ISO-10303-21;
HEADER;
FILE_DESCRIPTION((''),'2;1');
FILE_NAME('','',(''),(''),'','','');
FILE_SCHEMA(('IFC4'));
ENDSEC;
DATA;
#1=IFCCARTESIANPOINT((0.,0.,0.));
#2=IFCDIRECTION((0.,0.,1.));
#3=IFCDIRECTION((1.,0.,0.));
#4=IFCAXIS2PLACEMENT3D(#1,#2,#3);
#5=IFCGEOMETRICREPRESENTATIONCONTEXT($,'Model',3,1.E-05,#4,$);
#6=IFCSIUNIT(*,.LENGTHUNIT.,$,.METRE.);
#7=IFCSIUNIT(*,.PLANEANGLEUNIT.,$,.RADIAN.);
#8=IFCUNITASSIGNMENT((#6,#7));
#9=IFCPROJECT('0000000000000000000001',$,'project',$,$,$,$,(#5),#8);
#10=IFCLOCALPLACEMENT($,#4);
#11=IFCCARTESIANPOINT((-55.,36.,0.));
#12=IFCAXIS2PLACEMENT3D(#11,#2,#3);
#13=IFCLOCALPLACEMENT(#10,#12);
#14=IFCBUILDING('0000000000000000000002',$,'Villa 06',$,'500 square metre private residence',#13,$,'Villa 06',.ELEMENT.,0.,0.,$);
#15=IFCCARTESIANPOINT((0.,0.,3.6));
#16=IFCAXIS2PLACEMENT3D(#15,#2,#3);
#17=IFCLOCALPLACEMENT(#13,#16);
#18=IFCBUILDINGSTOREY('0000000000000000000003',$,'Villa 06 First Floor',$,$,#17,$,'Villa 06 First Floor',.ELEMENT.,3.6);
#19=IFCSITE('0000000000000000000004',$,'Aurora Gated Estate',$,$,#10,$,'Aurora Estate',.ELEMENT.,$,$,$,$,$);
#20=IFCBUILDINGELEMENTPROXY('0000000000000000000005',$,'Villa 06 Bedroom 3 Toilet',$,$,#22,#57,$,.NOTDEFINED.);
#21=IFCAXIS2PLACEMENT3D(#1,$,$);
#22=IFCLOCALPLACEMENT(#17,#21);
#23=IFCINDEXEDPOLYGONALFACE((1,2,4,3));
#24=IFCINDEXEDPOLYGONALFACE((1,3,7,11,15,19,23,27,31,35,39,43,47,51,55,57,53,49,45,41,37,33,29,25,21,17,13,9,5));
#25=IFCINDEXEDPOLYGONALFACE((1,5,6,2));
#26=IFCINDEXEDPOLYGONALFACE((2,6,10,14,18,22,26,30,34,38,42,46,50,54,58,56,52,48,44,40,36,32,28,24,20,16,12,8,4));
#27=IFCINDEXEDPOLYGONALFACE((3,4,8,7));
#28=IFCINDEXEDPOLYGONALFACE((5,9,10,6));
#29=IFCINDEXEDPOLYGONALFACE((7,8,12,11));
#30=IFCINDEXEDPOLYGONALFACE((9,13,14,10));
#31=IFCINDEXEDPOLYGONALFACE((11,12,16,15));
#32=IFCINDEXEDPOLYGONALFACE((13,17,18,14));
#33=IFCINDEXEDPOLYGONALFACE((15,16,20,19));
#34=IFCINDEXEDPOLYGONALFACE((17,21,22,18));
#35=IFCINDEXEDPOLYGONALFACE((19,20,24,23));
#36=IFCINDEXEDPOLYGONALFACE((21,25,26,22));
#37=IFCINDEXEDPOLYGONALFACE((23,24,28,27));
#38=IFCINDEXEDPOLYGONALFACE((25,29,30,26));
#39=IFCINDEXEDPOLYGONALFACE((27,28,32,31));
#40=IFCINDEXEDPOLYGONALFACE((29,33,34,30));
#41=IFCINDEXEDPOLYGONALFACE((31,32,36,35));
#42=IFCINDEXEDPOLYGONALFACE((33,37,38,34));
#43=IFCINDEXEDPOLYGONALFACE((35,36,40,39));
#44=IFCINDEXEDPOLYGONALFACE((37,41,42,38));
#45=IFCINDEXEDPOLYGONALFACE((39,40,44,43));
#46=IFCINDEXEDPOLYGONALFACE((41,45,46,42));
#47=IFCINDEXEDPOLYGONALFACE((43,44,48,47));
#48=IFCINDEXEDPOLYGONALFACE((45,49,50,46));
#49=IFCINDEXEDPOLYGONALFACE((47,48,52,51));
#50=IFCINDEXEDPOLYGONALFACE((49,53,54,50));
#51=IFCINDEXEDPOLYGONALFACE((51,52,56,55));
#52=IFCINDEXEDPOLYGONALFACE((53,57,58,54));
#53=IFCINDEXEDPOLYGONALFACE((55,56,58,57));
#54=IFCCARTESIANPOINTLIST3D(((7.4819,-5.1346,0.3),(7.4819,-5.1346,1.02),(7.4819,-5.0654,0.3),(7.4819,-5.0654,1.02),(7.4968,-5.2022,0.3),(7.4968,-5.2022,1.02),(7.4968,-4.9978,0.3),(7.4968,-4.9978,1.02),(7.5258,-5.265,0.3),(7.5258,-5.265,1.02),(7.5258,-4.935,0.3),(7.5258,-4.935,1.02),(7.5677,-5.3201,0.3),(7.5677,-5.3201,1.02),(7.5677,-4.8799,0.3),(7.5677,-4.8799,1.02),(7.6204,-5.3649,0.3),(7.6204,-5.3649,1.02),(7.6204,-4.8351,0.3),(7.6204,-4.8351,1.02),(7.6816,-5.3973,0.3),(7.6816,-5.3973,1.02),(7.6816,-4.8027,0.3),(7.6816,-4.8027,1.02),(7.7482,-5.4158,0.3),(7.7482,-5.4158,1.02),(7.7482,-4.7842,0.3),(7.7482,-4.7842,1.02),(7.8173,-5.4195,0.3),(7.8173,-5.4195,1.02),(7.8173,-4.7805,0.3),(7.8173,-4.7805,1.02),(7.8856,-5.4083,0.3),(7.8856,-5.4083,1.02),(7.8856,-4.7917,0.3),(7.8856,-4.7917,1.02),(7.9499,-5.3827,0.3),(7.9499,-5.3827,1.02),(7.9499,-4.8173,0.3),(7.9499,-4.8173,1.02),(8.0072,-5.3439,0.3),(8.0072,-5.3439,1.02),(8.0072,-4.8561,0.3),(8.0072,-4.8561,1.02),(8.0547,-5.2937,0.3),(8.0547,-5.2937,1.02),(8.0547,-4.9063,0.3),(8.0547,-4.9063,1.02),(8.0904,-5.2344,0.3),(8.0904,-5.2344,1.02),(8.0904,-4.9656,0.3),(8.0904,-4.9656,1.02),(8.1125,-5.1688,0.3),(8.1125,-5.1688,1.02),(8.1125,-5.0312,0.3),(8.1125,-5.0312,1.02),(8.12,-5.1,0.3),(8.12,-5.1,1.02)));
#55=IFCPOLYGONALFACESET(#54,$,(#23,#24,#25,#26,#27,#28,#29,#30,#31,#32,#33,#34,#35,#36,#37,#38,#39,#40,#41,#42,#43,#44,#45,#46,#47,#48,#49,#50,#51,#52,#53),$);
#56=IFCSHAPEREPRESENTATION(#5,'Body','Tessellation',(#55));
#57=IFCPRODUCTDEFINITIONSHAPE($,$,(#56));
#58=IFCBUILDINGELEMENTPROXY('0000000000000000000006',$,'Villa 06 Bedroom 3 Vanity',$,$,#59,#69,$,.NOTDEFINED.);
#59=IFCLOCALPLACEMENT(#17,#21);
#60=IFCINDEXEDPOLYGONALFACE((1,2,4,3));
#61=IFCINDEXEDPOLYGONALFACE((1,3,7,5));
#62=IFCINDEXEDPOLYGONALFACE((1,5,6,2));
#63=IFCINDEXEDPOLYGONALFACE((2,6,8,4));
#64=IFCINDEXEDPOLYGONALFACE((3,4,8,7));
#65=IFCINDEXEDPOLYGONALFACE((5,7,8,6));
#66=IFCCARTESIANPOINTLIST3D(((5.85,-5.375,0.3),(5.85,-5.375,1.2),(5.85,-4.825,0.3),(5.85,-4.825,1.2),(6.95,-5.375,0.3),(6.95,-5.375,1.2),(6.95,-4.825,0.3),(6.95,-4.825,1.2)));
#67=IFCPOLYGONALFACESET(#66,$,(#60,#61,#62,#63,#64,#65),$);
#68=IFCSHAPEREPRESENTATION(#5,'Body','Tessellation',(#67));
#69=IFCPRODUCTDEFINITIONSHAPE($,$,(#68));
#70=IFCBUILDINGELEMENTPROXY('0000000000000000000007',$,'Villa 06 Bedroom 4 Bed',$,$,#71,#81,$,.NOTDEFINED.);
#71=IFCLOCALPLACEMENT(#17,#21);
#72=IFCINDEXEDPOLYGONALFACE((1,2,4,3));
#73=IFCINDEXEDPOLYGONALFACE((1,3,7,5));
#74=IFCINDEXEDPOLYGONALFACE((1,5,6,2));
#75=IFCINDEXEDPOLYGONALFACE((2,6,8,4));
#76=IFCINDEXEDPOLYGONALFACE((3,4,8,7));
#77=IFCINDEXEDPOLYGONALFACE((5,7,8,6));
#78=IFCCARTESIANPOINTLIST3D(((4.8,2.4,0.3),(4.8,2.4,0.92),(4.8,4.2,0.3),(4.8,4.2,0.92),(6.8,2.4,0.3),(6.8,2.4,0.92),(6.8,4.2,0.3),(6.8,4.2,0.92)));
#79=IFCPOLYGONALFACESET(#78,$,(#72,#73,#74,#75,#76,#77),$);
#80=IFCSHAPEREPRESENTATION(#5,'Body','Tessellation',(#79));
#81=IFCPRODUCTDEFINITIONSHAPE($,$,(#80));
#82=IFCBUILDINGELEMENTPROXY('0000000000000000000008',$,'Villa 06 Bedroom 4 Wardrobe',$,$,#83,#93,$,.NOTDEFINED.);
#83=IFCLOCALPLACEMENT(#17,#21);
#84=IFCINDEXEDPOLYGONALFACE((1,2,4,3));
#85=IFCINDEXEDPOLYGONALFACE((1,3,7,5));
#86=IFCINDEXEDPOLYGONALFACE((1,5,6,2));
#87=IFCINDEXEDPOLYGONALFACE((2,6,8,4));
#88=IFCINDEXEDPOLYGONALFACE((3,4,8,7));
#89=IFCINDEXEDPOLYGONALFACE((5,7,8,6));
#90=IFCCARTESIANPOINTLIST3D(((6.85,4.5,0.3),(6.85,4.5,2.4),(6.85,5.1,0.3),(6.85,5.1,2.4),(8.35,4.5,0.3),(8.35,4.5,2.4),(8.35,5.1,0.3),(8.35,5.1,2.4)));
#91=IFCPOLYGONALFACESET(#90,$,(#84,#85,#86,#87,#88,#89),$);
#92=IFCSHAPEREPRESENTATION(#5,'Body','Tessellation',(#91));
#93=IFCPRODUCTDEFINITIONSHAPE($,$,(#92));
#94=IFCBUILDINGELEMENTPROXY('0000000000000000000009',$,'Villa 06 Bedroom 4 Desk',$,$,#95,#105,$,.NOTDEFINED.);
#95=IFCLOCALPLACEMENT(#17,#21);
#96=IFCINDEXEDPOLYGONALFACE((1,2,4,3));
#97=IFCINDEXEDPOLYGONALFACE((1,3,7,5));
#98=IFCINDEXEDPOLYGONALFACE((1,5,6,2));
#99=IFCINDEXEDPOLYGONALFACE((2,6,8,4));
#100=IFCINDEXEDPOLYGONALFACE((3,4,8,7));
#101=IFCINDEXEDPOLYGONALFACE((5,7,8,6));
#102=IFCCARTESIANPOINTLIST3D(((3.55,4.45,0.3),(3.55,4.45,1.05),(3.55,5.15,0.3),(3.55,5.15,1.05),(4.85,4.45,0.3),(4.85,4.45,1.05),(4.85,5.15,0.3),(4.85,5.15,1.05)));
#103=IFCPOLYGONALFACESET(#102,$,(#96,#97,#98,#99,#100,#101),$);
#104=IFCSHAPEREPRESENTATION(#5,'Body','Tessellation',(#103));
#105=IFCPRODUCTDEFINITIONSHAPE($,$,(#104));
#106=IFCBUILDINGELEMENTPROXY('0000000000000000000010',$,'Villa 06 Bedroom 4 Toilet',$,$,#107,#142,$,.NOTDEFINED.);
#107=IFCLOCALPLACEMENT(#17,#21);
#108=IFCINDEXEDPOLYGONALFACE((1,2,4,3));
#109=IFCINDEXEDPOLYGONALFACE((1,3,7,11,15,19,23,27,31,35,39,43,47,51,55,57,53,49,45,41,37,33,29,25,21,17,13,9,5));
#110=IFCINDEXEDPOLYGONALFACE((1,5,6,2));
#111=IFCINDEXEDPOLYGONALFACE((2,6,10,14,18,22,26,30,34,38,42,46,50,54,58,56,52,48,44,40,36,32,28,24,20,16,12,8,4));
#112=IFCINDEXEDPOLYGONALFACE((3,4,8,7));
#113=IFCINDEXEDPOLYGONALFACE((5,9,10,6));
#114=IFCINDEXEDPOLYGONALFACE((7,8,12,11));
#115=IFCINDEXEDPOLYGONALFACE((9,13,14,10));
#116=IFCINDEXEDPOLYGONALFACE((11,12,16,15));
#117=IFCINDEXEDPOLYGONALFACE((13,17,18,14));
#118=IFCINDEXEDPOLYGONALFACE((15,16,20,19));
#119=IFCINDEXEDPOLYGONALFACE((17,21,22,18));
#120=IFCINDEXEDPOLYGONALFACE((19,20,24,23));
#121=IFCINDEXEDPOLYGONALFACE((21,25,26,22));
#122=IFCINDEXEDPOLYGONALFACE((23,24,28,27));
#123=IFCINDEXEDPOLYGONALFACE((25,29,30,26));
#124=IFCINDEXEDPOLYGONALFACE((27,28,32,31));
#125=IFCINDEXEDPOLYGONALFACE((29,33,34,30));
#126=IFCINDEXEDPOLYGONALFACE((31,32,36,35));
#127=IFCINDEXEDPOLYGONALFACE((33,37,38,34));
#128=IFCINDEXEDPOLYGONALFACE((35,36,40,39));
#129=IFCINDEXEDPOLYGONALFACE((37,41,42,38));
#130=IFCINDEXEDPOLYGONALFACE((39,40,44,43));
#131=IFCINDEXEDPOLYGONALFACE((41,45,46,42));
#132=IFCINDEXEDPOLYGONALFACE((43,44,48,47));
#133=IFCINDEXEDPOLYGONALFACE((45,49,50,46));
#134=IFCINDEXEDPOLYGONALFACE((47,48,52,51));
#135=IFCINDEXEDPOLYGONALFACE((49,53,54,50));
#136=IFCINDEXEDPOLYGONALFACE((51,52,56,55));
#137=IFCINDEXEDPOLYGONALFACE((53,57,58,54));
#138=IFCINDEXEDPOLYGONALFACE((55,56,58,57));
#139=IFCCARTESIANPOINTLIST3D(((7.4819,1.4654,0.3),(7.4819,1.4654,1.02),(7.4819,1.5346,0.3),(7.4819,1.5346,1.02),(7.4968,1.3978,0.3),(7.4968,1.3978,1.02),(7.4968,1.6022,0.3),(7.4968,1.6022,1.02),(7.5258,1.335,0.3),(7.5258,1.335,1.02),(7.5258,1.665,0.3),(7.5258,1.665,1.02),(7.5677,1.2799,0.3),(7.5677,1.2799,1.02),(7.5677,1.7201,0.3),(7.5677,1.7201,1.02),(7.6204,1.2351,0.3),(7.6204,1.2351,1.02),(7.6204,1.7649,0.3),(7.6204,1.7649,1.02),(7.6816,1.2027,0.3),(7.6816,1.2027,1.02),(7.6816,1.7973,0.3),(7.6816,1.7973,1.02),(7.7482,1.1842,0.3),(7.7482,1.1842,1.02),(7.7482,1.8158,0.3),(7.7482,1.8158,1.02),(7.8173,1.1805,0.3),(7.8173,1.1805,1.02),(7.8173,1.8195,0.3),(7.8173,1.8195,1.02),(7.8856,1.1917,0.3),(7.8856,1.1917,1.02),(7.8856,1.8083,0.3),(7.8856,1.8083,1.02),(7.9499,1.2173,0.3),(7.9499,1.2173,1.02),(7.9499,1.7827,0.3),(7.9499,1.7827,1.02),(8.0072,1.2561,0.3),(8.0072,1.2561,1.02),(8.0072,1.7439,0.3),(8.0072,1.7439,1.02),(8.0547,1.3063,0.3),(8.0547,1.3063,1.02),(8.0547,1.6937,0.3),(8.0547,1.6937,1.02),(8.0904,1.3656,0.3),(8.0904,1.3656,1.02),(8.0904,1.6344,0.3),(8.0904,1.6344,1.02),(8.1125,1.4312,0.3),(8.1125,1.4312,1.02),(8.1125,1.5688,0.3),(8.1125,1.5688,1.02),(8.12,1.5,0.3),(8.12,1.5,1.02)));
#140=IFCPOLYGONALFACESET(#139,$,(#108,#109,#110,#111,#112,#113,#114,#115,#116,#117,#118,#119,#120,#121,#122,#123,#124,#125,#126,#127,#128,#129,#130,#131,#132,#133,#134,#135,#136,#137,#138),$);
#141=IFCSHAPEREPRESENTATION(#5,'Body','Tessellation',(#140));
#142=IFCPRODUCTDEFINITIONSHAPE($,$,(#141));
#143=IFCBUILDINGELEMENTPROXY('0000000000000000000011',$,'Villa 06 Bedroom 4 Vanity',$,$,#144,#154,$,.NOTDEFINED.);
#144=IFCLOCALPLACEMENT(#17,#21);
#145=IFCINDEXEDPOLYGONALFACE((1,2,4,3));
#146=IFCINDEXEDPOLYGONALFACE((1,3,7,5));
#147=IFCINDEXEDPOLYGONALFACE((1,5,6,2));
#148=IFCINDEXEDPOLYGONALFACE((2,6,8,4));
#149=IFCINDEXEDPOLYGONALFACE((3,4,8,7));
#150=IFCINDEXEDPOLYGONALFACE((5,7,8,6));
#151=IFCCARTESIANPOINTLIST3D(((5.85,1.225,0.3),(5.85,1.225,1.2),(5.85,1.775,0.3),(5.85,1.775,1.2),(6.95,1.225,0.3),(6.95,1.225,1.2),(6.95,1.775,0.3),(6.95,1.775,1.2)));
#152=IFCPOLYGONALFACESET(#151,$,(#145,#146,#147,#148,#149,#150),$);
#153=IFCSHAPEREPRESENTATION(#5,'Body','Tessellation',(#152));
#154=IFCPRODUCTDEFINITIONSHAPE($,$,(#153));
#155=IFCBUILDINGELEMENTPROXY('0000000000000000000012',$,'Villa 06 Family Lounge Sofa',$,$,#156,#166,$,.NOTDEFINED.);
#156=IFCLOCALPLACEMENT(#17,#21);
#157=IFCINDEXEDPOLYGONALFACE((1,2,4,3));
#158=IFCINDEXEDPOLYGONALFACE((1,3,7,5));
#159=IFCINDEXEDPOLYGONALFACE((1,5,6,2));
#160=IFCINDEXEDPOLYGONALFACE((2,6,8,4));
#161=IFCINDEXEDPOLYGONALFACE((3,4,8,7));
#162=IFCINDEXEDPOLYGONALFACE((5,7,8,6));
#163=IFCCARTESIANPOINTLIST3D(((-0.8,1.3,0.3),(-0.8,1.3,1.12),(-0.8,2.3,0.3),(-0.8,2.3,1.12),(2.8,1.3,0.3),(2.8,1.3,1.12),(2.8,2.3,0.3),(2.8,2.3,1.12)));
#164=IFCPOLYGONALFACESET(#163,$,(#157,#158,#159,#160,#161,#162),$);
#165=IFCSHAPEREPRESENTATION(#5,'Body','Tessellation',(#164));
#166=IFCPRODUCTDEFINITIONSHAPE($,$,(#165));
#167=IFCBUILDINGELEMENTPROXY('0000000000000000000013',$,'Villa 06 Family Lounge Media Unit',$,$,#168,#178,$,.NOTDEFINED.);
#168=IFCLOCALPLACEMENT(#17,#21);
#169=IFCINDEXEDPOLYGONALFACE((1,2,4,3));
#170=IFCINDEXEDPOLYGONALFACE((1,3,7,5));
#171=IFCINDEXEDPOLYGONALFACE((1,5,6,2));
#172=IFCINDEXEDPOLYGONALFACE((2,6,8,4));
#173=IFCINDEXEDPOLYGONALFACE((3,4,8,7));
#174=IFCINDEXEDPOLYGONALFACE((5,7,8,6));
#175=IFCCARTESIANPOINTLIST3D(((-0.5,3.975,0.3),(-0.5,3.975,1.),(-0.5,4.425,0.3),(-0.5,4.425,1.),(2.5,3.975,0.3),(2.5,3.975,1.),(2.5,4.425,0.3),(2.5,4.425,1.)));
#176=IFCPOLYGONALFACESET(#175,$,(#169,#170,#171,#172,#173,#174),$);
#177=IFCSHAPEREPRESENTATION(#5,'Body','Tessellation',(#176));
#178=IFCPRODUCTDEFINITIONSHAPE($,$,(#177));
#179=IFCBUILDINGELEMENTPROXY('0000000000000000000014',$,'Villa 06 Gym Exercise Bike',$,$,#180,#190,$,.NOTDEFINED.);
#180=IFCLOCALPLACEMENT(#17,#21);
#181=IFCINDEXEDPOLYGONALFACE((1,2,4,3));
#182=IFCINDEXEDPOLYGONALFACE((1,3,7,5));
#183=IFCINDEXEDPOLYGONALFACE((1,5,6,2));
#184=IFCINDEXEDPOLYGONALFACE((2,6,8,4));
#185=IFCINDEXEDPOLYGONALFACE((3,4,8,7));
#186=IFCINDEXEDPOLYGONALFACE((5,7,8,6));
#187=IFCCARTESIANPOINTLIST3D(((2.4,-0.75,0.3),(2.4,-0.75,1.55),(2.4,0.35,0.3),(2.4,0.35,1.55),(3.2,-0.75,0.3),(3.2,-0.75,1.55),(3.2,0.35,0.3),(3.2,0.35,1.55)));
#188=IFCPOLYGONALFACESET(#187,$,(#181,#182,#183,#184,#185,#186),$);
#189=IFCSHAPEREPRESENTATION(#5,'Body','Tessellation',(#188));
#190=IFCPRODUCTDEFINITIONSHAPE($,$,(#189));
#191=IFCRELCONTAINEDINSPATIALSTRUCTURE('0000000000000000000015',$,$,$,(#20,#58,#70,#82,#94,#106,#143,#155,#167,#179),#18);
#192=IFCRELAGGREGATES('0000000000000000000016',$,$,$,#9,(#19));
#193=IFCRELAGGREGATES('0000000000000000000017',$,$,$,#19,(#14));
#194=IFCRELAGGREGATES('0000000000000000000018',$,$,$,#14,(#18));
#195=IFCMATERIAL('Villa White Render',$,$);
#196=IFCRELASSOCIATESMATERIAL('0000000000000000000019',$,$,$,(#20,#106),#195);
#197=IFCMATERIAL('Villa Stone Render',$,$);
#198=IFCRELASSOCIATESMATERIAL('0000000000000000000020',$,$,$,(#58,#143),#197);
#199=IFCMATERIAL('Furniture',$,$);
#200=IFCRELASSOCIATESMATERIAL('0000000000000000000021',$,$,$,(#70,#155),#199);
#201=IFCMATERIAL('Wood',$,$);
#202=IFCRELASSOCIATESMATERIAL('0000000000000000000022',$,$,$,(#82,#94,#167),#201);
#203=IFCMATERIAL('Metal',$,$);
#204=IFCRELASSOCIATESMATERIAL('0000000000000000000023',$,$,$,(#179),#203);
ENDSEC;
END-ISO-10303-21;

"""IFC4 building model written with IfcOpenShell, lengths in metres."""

from ifc_helpers import new_model, si_unit, frame, origin_with_axes, origin_2d_with_axis, place, context, project, spatial, rectangle, circle, extrude, material, element, save


model = new_model("IFC4")

# Units and contexts
model_context = context("Model", 3, precision=1e-05, world=origin_with_axes())
ifc_project = project(units=[si_unit("LENGTHUNIT", "METRE"), si_unit("PLANEANGLEUNIT", "RADIAN")], contexts=[model_context])

# Site, building, storey
site_placement = place(None, origin_with_axes())
site = spatial("IfcSite", under=ifc_project, at=site_placement, Name="Aurora Gated Estate", LongName="Aurora Estate", CompositionType="ELEMENT")
building_placement = place(site_placement, frame((-55.0, 36.0, 0.0), z_axis=(0.0, 0.0, 1.0), x_axis=(1.0, 0.0, 0.0)))
building = spatial("IfcBuilding", under=site, at=building_placement, Name="Villa 06", ObjectType="500 square metre private residence", LongName="Villa 06", CompositionType="ELEMENT", ElevationOfRefHeight=0.0, ElevationOfTerrain=0.0)
storey_placement = place(building_placement, frame((0.0, 0.0, 3.6), z_axis=(0.0, 0.0, 1.0), x_axis=(1.0, 0.0, 0.0)))
storey = spatial("IfcBuildingStorey", under=building, at=storey_placement, Name="Villa 06 First Floor", LongName="Villa 06 First Floor", CompositionType="ELEMENT", Elevation=3.6)

# Shared definitions
ifc_material_1 = material(Name="Villa Stone Render")

# Building element proxies
ifc_material_2 = material(Name="Wood")
ifc_material_3 = material(Name="Villa White Render")
ifc_material_4 = material(Name="Furniture")
proxy_1_placement = place(storey_placement, frame((7.8, -5.1, 0.3), z_axis=(0.0, 0.0, 1.0), x_axis=(1.0, 0.0, 0.0)))
element("IfcBuildingElementProxy", 1, at=proxy_1_placement, inside=storey, material=ifc_material_3, Name="Villa 06 Bedroom 3 Toilet", PredefinedType="NOTDEFINED", context=model_context, shape_type="SweptSolid", body=[
    extrude(circle(Radius=0.32, at=origin_2d_with_axis()), origin_with_axes(), (0.0, 0.0, 1.0), 0.72),
])
proxy_2_placement = place(storey_placement, frame((6.4, -5.1, 0.3), z_axis=(0.0, 0.0, 1.0), x_axis=(1.0, 0.0, 0.0)))
element("IfcBuildingElementProxy", 2, at=proxy_2_placement, inside=storey, material=ifc_material_1, Name="Villa 06 Bedroom 3 Vanity", PredefinedType="NOTDEFINED", context=model_context, shape_type="SweptSolid", body=[
    extrude(rectangle(XDim=1.1, YDim=0.55, at=origin_2d_with_axis()), origin_with_axes(), (0.0, 0.0, 1.0), 0.9),
])
proxy_3_placement = place(storey_placement, frame((5.8, 3.3, 0.3), z_axis=(0.0, 0.0, 1.0), x_axis=(1.0, 0.0, 0.0)))
element("IfcBuildingElementProxy", 3, at=proxy_3_placement, inside=storey, material=ifc_material_4, Name="Villa 06 Bedroom 4 Bed", PredefinedType="NOTDEFINED", context=model_context, shape_type="SweptSolid", body=[
    extrude(rectangle(XDim=2.0, YDim=1.8, at=origin_2d_with_axis()), origin_with_axes(), (0.0, 0.0, 1.0), 0.62),
])
proxy_4_placement = place(storey_placement, frame((7.6, 4.8, 0.3), z_axis=(0.0, 0.0, 1.0), x_axis=(1.0, 0.0, 0.0)))
element("IfcBuildingElementProxy", 4, at=proxy_4_placement, inside=storey, material=ifc_material_2, Name="Villa 06 Bedroom 4 Wardrobe", PredefinedType="NOTDEFINED", context=model_context, shape_type="SweptSolid", body=[
    extrude(rectangle(XDim=1.5, YDim=0.6, at=origin_2d_with_axis()), origin_with_axes(), (0.0, 0.0, 1.0), 2.1),
])
proxy_5_placement = place(storey_placement, frame((4.2, 4.8, 0.3), z_axis=(0.0, 0.0, 1.0), x_axis=(1.0, 0.0, 0.0)))
element("IfcBuildingElementProxy", 5, at=proxy_5_placement, inside=storey, material=ifc_material_2, Name="Villa 06 Bedroom 4 Desk", PredefinedType="NOTDEFINED", context=model_context, shape_type="SweptSolid", body=[
    extrude(rectangle(XDim=1.3, YDim=0.7, at=origin_2d_with_axis()), origin_with_axes(), (0.0, 0.0, 1.0), 0.75),
])
proxy_6_placement = place(storey_placement, frame((7.8, 1.5, 0.3), z_axis=(0.0, 0.0, 1.0), x_axis=(1.0, 0.0, 0.0)))
element("IfcBuildingElementProxy", 6, at=proxy_6_placement, inside=storey, material=ifc_material_3, Name="Villa 06 Bedroom 4 Toilet", PredefinedType="NOTDEFINED", context=model_context, shape_type="SweptSolid", body=[
    extrude(circle(Radius=0.32, at=origin_2d_with_axis()), origin_with_axes(), (0.0, 0.0, 1.0), 0.72),
])
proxy_7_placement = place(storey_placement, frame((6.4, 1.5, 0.3), z_axis=(0.0, 0.0, 1.0), x_axis=(1.0, 0.0, 0.0)))
element("IfcBuildingElementProxy", 7, at=proxy_7_placement, inside=storey, material=ifc_material_1, Name="Villa 06 Bedroom 4 Vanity", PredefinedType="NOTDEFINED", context=model_context, shape_type="SweptSolid", body=[
    extrude(rectangle(XDim=1.1, YDim=0.55, at=origin_2d_with_axis()), origin_with_axes(), (0.0, 0.0, 1.0), 0.9),
])
proxy_8_placement = place(storey_placement, frame((1.0, 1.8, 0.3), z_axis=(0.0, 0.0, 1.0), x_axis=(1.0, 0.0, 0.0)))
element("IfcBuildingElementProxy", 8, at=proxy_8_placement, inside=storey, material=ifc_material_4, Name="Villa 06 Family Lounge Sofa", PredefinedType="NOTDEFINED", context=model_context, shape_type="SweptSolid", body=[
    extrude(rectangle(XDim=3.6, YDim=1.0, at=origin_2d_with_axis()), origin_with_axes(), (0.0, 0.0, 1.0), 0.82),
])
proxy_9_placement = place(storey_placement, frame((1.0, 4.2, 0.3), z_axis=(0.0, 0.0, 1.0), x_axis=(1.0, 0.0, 0.0)))
element("IfcBuildingElementProxy", 9, at=proxy_9_placement, inside=storey, material=ifc_material_2, Name="Villa 06 Family Lounge Media Unit", PredefinedType="NOTDEFINED", context=model_context, shape_type="SweptSolid", body=[
    extrude(rectangle(XDim=3.0, YDim=0.45, at=origin_2d_with_axis()), origin_with_axes(), (0.0, 0.0, 1.0), 0.7),
])
ifc_material_5 = material(Name="Metal")
proxy_10_placement = place(storey_placement, frame((2.8, -0.2, 0.3), z_axis=(0.0, 0.0, 1.0), x_axis=(1.0, 0.0, 0.0)))
element("IfcBuildingElementProxy", 10, at=proxy_10_placement, inside=storey, material=ifc_material_5, Name="Villa 06 Gym Exercise Bike", PredefinedType="NOTDEFINED", context=model_context, shape_type="SweptSolid", body=[
    extrude(rectangle(XDim=0.8, YDim=1.1, at=origin_2d_with_axis()), origin_with_axes(), (0.0, 0.0, 1.0), 1.25),
])

save(model, "model.ifc")
